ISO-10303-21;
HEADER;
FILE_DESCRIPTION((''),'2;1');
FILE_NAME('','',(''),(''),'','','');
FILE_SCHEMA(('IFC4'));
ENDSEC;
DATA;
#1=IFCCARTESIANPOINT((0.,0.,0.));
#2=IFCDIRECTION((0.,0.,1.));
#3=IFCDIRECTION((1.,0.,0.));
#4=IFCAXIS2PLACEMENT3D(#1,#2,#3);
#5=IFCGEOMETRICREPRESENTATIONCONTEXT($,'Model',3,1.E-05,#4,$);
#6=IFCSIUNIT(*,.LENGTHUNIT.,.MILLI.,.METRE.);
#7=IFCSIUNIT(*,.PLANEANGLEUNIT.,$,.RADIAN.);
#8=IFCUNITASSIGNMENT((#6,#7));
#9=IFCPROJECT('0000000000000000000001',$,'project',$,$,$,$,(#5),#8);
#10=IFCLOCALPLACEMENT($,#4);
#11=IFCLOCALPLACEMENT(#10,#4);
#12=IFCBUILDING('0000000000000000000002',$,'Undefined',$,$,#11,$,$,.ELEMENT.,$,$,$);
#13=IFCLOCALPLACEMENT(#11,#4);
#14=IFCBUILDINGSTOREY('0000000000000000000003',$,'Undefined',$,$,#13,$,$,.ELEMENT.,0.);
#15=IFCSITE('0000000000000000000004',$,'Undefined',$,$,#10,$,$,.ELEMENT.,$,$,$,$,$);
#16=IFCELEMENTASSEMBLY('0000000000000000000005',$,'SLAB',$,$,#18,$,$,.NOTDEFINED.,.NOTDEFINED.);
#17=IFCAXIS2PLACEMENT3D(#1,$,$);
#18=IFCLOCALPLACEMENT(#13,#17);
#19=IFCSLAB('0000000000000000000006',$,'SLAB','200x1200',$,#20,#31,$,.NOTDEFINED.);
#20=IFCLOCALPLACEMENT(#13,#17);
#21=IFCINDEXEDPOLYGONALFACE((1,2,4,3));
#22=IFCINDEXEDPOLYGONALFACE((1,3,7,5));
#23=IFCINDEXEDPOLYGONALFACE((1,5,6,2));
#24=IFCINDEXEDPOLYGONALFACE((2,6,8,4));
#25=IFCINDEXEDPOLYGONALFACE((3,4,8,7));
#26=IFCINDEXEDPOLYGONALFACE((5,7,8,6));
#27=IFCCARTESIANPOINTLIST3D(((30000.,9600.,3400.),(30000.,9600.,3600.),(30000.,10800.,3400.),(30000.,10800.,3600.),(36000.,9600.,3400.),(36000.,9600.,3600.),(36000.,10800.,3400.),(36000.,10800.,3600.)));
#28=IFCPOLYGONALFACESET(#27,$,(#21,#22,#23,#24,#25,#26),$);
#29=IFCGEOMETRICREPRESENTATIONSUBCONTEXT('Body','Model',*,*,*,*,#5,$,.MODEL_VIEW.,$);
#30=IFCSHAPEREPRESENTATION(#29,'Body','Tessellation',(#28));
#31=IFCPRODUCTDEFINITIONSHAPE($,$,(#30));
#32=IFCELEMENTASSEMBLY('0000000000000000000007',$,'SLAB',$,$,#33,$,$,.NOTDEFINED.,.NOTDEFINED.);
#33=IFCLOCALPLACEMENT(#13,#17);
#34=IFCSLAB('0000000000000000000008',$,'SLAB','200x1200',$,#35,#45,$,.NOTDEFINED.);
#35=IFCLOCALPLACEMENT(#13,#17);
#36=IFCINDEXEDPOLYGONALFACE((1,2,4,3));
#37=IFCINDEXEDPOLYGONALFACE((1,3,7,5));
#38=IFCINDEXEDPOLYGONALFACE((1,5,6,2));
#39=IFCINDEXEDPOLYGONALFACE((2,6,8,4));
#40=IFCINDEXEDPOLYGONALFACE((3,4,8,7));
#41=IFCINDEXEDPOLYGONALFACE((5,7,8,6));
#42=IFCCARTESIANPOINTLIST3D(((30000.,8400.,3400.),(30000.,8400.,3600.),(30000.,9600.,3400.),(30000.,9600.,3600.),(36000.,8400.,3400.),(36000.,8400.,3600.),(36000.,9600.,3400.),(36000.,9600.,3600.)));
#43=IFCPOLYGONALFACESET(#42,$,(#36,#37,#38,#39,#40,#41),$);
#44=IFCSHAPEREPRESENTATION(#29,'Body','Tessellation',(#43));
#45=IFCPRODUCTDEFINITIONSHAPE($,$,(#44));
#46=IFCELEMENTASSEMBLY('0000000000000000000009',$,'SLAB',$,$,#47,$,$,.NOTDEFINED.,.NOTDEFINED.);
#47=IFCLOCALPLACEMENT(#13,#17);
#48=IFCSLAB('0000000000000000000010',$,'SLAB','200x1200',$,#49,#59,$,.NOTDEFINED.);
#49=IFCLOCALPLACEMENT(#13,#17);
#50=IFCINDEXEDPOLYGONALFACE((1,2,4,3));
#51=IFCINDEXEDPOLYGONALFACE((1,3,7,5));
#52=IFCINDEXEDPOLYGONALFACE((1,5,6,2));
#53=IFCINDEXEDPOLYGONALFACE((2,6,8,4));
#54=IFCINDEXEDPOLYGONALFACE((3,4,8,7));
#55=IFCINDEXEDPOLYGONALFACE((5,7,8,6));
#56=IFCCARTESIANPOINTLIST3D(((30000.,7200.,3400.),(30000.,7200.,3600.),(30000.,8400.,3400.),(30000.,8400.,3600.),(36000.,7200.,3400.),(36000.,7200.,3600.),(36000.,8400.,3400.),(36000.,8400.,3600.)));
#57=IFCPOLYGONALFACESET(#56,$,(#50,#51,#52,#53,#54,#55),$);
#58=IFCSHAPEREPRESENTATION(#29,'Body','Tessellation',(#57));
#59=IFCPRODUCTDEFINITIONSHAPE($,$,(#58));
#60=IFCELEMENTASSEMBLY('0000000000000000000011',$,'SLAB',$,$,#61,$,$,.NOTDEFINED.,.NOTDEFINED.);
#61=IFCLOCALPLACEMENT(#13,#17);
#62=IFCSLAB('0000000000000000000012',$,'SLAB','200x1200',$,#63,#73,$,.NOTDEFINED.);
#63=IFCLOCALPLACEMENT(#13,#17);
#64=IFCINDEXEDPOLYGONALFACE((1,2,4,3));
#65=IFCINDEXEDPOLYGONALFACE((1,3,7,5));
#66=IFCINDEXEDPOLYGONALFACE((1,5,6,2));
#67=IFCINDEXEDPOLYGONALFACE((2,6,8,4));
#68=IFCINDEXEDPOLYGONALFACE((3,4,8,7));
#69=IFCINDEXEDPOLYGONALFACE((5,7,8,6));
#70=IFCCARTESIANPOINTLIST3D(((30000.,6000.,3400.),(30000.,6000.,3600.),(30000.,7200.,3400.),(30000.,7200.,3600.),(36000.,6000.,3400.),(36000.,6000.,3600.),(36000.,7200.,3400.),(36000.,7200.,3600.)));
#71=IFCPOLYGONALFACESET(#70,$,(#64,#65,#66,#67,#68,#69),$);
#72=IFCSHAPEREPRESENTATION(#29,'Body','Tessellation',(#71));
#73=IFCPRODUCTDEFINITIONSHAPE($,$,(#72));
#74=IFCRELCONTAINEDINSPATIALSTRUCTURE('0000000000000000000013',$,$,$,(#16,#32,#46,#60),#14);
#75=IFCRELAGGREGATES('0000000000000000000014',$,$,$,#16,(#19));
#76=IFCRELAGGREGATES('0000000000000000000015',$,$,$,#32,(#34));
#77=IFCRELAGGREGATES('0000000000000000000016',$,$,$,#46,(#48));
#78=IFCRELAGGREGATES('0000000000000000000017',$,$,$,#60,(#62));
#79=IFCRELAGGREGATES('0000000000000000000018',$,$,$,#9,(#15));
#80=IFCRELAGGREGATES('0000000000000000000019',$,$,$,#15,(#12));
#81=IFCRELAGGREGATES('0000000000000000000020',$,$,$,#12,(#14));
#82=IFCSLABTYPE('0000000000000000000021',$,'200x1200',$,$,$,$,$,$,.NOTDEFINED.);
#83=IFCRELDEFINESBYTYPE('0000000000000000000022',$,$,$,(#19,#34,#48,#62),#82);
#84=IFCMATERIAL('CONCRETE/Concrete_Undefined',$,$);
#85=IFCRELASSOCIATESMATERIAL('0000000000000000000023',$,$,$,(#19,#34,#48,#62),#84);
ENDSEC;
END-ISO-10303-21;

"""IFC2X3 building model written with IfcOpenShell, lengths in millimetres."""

from ifc_helpers import new_model, si_unit, frame, origin_with_axes, place, context, subcontext, project, spatial, polyline, outline, extrude, material, type_object, element, aggregate, save


model = new_model("IFC2X3")

# Units and contexts
model_context = context("Model", 3, precision=1e-05, world=origin_with_axes())
body_context = subcontext(model_context, "Body", "Model", "MODEL_VIEW")
ifc_project = project(units=[si_unit("LENGTHUNIT", "METRE", prefix="MILLI"), si_unit("PLANEANGLEUNIT", "RADIAN")], contexts=[model_context])

# Site, building, storey
site_placement = place(None, origin_with_axes())
site = spatial("IfcSite", under=ifc_project, at=site_placement, Name="Undefined", CompositionType="ELEMENT")
building_placement = place(site_placement, origin_with_axes())
building = spatial("IfcBuilding", under=site, at=building_placement, Name="Undefined", CompositionType="ELEMENT")
storey_placement = place(building_placement, origin_with_axes())
storey = spatial("IfcBuildingStorey", under=building, at=storey_placement, Name="Undefined", CompositionType="ELEMENT", Elevation=0.0)

# Shared definitions
ifc_material = material(Name="CONCRETE/Concrete_Undefined")

# Element assemblies, slabs
slab_type = type_object("IfcSlabType", Name="200x1200", PredefinedType="NOTDEFINED")
assembly_1_placement = place(storey_placement, origin_with_axes())
assembly_1 = element("IfcElementAssembly", 1, at=assembly_1_placement, inside=storey, Name="SLAB", AssemblyPlace="NOTDEFINED", PredefinedType="NOTDEFINED")
slab_1_placement = place(assembly_1_placement, frame((36000.0, 9600.0, 3500.0), z_axis=(0.0, 0.0, 1.0), x_axis=(0.0, 1.0, 0.0)))
slab_1 = element("IfcSlab", 2, at=slab_1_placement, type_object=slab_type, material=ifc_material, Name="SLAB", Description="200x1200", PredefinedType="NOTDEFINED", context=body_context, shape_type="SweptSolid", body=[
    extrude(outline(polyline([(0.0, 0.0), (1200.0, 0.0), (1200.0, 6000.0), (0.0, 6000.0), (0.0, 0.0)])), frame((0.0, 0.0, -100.0), z_axis=(0.0, 0.0, 1.0), x_axis=(1.0, 0.0, 0.0)), (0.0, 0.0, 1.0), 200.0),
])
aggregate(assembly_1, [slab_1])
assembly_2_placement = place(storey_placement, origin_with_axes())
assembly_2 = element("IfcElementAssembly", 3, at=assembly_2_placement, inside=storey, Name="SLAB", AssemblyPlace="NOTDEFINED", PredefinedType="NOTDEFINED")
slab_2_placement = place(assembly_2_placement, frame((36000.0, 8400.0, 3500.0), z_axis=(0.0, 0.0, 1.0), x_axis=(0.0, 1.0, 0.0)))
slab_2 = element("IfcSlab", 4, at=slab_2_placement, type_object=slab_type, material=ifc_material, Name="SLAB", Description="200x1200", PredefinedType="NOTDEFINED", context=body_context, shape_type="SweptSolid", body=[
    extrude(outline(polyline([(0.0, 0.0), (1200.0, 0.0), (1200.0, 6000.0), (0.0, 6000.0), (0.0, 0.0)])), frame((0.0, 0.0, -100.0), z_axis=(0.0, 0.0, 1.0), x_axis=(1.0, 0.0, 0.0)), (0.0, 0.0, 1.0), 200.0),
])
aggregate(assembly_2, [slab_2])
assembly_3_placement = place(storey_placement, origin_with_axes())
assembly_3 = element("IfcElementAssembly", 5, at=assembly_3_placement, inside=storey, Name="SLAB", AssemblyPlace="NOTDEFINED", PredefinedType="NOTDEFINED")
slab_3_placement = place(assembly_3_placement, frame((36000.0, 7200.0, 3500.0), z_axis=(0.0, 0.0, 1.0), x_axis=(0.0, 1.0, 0.0)))
slab_3 = element("IfcSlab", 6, at=slab_3_placement, type_object=slab_type, material=ifc_material, Name="SLAB", Description="200x1200", PredefinedType="NOTDEFINED", context=body_context, shape_type="SweptSolid", body=[
    extrude(outline(polyline([(0.0, 0.0), (1200.0, 0.0), (1200.0, 6000.0), (0.0, 6000.0), (0.0, 0.0)])), frame((0.0, 0.0, -100.0), z_axis=(0.0, 0.0, 1.0), x_axis=(1.0, 0.0, 0.0)), (0.0, 0.0, 1.0), 200.0),
])
aggregate(assembly_3, [slab_3])
assembly_4_placement = place(storey_placement, origin_with_axes())
assembly_4 = element("IfcElementAssembly", 7, at=assembly_4_placement, inside=storey, Name="SLAB", AssemblyPlace="NOTDEFINED", PredefinedType="NOTDEFINED")
slab_4_placement = place(assembly_4_placement, frame((36000.0, 6000.0, 3500.0), z_axis=(0.0, 0.0, 1.0), x_axis=(0.0, 1.0, 0.0)))
slab_4 = element("IfcSlab", 8, at=slab_4_placement, type_object=slab_type, material=ifc_material, Name="SLAB", Description="200x1200", PredefinedType="NOTDEFINED", context=body_context, shape_type="SweptSolid", body=[
    extrude(outline(polyline([(0.0, 0.0), (1200.0, 0.0), (1200.0, 6000.0), (0.0, 6000.0), (0.0, 0.0)])), frame((0.0, 0.0, -100.0), z_axis=(0.0, 0.0, 1.0), x_axis=(1.0, 0.0, 0.0)), (0.0, 0.0, 1.0), 200.0),
])
aggregate(assembly_4, [slab_4])

save(model, "model.ifc")
